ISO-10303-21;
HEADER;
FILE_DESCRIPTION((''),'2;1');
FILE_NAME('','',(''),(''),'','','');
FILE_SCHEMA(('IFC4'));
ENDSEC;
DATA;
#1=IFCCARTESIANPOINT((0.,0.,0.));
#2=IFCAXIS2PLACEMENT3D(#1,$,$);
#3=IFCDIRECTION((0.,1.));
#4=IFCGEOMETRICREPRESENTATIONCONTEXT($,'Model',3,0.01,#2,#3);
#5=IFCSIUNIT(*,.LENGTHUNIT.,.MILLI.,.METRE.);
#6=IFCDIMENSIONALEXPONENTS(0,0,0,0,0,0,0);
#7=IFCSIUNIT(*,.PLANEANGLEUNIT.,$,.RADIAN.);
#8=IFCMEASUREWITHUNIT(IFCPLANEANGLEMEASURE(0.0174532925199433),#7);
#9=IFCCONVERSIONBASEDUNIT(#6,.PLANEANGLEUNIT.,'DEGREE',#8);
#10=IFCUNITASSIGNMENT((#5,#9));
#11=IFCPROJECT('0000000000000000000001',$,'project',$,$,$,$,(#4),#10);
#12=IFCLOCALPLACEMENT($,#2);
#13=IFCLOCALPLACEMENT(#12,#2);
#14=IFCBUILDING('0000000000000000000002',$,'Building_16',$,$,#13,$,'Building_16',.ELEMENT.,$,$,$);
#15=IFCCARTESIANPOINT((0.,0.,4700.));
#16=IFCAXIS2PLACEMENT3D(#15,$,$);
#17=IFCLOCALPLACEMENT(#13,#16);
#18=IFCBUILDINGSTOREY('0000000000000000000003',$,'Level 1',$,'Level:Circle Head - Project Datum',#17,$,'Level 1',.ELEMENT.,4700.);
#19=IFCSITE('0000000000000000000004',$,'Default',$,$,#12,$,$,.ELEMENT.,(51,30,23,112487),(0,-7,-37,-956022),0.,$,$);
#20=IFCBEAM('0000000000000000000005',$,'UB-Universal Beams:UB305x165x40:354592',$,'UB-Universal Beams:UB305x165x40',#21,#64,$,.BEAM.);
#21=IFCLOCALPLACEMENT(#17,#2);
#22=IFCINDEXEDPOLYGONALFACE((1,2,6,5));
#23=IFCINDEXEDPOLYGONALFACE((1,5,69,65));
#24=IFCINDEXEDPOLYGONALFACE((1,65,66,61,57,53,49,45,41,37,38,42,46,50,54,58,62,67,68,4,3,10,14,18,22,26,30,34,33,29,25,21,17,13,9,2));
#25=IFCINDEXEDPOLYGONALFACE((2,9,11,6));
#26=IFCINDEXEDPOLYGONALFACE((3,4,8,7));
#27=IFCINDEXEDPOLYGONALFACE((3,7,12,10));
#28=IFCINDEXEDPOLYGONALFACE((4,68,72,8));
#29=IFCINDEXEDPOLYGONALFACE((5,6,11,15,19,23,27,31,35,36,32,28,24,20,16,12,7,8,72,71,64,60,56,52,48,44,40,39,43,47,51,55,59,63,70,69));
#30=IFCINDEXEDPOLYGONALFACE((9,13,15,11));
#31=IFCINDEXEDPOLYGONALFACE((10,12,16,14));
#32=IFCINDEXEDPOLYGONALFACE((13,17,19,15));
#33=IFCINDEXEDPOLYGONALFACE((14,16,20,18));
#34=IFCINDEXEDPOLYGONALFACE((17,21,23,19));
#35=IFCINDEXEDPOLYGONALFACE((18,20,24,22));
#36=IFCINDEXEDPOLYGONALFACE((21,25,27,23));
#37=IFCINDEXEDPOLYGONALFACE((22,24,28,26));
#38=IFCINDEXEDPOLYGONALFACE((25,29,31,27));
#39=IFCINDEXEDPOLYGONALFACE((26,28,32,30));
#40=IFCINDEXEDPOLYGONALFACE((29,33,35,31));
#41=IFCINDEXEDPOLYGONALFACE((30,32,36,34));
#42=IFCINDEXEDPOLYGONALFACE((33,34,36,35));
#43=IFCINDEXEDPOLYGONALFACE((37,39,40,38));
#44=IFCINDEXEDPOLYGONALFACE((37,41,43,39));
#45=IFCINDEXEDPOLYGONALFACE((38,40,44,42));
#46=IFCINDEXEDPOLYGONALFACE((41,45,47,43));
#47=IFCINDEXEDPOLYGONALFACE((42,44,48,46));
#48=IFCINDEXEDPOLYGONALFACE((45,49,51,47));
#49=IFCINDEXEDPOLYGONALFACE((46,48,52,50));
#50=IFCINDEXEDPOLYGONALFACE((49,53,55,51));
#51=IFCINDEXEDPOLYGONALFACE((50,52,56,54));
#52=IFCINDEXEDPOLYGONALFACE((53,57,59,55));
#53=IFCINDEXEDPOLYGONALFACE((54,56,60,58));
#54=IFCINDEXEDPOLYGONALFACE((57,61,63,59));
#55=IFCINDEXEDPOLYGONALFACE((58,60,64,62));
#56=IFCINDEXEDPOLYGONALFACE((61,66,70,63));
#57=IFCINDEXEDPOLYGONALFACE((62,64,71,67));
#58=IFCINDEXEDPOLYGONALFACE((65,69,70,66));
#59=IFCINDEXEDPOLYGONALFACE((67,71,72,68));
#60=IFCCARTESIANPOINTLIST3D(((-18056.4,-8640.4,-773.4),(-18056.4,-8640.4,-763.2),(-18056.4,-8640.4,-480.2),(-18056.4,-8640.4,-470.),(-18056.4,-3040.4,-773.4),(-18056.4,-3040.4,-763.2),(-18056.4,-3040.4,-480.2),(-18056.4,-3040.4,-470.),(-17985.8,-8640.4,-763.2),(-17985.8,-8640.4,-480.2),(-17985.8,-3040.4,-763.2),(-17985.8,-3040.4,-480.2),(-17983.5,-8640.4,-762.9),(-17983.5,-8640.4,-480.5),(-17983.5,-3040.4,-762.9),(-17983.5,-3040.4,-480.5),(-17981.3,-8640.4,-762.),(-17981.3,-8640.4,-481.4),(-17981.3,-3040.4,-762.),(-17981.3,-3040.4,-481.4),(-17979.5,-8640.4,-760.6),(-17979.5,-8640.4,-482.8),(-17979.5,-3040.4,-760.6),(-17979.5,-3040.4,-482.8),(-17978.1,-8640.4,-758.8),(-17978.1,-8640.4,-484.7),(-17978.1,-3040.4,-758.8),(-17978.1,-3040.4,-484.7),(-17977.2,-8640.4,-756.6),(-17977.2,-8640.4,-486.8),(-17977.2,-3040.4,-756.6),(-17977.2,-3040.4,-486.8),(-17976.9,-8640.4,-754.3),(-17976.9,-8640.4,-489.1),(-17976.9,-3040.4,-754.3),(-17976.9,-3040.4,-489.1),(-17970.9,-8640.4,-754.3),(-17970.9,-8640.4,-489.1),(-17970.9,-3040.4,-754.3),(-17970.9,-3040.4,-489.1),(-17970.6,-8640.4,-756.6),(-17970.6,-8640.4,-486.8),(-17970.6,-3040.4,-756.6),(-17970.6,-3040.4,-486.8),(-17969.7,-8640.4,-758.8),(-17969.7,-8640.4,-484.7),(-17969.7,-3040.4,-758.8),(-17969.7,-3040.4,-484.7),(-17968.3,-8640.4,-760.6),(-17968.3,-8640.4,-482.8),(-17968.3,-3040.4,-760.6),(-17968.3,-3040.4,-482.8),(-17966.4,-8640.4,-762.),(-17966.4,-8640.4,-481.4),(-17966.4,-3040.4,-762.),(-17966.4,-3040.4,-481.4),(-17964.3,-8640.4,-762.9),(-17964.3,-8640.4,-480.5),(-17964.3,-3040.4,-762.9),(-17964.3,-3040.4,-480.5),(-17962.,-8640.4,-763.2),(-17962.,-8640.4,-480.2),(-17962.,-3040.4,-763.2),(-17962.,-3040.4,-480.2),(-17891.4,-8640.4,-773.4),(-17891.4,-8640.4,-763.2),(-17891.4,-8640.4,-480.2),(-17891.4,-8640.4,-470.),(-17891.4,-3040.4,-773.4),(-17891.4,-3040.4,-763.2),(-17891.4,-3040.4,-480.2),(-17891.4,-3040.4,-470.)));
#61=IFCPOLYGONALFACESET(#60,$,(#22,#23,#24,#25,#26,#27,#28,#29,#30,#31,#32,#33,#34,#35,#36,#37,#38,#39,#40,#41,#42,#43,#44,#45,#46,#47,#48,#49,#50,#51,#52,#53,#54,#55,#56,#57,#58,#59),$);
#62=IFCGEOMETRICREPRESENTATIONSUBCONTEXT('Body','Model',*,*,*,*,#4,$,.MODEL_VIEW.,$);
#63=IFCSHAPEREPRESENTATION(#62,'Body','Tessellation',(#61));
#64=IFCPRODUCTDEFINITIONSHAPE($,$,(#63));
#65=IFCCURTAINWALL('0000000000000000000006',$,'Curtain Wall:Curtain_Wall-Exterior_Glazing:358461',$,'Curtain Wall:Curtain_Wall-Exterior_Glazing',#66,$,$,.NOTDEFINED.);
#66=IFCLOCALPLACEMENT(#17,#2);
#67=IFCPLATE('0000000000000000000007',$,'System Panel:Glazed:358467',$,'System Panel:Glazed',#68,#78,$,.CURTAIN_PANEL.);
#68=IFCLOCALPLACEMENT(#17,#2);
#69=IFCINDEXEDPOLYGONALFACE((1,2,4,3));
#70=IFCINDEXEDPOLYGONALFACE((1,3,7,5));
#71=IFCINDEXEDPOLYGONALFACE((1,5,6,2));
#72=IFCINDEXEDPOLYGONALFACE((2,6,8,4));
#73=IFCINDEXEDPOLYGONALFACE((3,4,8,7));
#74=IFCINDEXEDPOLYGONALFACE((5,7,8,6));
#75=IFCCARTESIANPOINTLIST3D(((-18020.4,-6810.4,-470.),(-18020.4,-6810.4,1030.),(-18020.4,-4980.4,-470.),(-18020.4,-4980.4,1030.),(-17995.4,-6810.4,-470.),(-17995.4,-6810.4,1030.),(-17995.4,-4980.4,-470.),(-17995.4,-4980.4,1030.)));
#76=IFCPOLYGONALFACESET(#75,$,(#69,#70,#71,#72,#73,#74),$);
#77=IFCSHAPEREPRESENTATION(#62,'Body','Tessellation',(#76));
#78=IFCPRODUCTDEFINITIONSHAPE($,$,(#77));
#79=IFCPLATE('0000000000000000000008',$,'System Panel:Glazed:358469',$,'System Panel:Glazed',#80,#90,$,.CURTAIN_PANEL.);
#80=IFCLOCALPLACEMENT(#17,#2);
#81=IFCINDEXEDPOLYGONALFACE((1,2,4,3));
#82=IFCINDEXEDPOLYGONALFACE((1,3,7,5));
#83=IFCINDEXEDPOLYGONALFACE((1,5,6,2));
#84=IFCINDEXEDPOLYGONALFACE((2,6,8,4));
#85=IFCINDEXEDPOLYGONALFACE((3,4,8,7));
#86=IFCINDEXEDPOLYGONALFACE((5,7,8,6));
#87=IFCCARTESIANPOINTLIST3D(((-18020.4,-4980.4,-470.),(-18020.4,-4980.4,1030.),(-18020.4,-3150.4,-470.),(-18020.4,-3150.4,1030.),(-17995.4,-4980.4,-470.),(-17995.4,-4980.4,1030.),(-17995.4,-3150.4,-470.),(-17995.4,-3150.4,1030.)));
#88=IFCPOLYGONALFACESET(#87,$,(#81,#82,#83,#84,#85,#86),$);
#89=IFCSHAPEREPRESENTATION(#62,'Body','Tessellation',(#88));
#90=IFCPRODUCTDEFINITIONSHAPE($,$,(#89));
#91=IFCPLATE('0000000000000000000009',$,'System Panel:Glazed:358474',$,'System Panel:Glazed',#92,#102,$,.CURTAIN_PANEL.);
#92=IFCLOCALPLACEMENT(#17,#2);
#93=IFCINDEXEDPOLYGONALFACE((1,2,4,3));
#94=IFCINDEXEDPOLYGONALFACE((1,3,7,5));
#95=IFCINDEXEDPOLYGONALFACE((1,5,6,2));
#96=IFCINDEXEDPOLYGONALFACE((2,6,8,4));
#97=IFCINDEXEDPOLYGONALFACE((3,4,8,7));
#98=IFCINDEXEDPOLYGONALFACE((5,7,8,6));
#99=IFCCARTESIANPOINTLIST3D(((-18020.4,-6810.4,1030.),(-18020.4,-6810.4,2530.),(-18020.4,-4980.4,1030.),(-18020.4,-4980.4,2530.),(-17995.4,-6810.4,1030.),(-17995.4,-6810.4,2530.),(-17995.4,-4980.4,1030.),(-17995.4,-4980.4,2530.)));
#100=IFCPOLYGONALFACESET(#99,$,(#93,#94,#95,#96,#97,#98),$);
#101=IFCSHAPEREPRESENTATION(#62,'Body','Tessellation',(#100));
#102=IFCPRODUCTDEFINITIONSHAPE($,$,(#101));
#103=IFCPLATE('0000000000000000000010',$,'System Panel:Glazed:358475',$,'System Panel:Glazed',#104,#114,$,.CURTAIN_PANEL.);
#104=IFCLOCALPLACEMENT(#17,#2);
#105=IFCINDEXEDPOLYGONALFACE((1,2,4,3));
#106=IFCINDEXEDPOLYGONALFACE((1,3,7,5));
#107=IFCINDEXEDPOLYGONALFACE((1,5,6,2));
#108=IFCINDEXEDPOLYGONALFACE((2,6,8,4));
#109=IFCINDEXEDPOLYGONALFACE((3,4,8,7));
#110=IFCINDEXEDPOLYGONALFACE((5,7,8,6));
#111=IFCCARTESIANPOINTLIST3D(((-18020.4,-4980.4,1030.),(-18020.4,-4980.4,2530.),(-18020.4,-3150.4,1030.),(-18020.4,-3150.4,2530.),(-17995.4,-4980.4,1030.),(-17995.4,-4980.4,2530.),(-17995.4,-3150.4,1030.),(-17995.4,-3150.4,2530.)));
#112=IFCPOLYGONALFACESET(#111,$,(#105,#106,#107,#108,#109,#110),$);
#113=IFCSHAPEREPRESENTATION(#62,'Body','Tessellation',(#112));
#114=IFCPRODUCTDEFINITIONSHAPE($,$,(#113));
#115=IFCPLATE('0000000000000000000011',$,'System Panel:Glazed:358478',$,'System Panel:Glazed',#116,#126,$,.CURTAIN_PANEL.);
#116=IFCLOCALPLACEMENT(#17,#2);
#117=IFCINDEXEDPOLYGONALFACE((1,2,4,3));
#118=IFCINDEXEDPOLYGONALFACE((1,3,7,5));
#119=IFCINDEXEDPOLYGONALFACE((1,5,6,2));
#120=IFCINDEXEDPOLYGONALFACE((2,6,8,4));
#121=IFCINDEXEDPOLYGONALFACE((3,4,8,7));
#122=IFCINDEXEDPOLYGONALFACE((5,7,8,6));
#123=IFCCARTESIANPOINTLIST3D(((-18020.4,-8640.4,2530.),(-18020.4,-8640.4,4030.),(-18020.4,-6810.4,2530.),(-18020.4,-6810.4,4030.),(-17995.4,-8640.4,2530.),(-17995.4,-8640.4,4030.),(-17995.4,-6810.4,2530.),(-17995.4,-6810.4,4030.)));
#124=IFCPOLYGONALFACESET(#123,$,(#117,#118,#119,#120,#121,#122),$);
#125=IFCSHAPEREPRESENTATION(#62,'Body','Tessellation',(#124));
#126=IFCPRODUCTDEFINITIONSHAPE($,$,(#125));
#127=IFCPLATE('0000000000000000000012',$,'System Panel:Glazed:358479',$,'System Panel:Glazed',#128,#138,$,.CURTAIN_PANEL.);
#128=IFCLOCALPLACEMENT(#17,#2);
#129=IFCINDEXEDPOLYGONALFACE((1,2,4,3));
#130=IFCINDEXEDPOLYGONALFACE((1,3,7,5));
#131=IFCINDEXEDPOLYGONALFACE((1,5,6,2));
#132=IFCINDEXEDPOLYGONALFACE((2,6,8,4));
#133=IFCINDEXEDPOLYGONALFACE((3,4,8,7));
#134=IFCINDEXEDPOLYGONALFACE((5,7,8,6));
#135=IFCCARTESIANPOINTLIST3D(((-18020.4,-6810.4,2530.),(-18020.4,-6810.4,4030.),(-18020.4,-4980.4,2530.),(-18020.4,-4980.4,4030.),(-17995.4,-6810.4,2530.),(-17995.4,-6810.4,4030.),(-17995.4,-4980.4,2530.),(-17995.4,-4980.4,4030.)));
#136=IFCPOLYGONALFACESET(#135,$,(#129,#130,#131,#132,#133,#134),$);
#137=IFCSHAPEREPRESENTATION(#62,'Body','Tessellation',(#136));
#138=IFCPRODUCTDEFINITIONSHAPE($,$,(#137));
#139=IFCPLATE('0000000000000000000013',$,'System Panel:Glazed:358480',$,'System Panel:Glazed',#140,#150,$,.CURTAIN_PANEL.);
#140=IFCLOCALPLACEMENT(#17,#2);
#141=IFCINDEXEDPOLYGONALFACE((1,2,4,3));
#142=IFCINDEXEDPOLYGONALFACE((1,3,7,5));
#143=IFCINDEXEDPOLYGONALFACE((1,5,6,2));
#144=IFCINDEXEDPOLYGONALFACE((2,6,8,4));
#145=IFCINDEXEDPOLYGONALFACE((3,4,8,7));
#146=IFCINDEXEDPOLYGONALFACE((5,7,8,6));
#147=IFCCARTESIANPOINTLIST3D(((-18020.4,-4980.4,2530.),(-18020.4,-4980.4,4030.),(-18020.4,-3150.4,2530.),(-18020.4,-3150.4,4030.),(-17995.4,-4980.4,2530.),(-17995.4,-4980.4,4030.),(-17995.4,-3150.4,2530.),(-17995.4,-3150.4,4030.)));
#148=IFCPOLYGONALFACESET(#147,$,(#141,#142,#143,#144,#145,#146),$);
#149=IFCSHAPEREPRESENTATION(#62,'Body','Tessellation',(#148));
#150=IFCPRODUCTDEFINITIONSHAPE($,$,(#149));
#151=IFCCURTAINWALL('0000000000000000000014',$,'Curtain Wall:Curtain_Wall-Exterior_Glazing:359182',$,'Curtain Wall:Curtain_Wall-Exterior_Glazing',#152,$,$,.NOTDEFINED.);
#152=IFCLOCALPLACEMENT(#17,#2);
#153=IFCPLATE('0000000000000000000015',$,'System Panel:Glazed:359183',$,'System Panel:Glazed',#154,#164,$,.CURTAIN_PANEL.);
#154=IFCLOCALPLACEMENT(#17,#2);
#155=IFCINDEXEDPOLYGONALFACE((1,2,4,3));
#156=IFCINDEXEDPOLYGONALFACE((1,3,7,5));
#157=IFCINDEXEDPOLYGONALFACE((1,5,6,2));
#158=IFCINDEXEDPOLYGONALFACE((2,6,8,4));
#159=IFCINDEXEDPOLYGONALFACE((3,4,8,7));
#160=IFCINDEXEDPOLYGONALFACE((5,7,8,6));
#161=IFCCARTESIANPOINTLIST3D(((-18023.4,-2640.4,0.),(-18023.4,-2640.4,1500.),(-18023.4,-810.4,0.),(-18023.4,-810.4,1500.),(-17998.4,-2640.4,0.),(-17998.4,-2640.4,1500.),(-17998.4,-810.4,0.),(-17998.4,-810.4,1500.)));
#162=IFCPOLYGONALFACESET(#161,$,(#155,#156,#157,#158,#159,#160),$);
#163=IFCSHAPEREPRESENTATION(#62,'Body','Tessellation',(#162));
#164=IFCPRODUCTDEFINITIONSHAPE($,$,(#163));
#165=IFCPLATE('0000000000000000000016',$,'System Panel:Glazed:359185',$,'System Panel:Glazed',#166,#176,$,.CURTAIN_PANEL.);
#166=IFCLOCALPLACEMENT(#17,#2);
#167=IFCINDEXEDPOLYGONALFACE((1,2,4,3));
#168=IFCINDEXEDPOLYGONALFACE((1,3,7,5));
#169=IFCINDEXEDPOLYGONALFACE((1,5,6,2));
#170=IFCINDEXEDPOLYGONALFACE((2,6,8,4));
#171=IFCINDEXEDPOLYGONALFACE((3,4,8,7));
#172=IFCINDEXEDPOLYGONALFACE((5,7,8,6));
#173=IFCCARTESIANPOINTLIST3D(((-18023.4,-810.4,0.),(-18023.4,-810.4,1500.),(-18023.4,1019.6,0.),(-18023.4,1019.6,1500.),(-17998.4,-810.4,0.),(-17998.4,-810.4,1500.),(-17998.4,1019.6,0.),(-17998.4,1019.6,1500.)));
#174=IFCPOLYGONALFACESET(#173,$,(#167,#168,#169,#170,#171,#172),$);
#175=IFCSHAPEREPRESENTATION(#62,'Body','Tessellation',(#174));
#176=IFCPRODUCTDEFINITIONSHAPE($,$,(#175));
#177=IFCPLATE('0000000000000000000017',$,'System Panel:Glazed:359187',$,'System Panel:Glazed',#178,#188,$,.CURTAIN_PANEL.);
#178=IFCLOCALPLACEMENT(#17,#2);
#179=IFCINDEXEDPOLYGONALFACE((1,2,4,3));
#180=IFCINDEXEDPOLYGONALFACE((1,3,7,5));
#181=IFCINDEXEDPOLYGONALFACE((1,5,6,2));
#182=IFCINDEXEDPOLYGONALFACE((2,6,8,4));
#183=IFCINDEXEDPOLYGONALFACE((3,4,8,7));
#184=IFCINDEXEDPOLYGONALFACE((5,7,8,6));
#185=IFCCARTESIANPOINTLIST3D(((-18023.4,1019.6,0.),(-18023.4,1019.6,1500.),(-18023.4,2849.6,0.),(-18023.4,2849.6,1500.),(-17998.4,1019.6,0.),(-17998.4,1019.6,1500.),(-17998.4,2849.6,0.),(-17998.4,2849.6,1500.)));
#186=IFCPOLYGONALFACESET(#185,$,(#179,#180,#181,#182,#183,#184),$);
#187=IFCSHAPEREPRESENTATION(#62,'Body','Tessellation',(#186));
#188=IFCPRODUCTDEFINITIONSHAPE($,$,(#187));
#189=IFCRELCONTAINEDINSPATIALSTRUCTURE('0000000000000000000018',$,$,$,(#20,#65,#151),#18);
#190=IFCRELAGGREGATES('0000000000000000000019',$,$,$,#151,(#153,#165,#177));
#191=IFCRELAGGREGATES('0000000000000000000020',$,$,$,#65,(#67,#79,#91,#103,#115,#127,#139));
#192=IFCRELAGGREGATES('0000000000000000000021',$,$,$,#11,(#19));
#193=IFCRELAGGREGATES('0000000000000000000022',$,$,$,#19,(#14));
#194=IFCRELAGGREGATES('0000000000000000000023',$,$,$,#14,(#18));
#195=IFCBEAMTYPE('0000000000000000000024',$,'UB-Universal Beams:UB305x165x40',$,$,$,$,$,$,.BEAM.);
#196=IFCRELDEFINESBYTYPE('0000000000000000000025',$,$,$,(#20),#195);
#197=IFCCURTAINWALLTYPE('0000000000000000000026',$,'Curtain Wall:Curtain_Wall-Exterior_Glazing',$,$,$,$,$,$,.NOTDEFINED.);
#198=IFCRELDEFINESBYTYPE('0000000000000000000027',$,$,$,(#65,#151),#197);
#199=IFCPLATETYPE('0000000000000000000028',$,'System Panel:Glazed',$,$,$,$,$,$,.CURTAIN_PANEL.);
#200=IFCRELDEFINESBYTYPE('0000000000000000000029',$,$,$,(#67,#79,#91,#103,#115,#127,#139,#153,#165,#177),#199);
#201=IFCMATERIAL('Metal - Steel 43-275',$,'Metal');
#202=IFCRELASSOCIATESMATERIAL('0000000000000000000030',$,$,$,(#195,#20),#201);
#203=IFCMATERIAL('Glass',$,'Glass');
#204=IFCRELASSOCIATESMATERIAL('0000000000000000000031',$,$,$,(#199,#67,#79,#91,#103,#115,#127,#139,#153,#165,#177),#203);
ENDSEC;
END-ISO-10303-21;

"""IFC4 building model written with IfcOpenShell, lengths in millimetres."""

from ifc_helpers import new_model, entity, si_unit, converted_unit, direction, frame, origin, place, context, subcontext, project, spatial, line, arc, indexed_curve, outline, extrude, source, transform, mapped, material, type_object, type_shapes, element, aggregate, save


model = new_model("IFC4")

# Units and contexts
model_context = context("Model", 3, precision=0.01, world=origin(), true_north=direction((0.0, 1.0)))
body_context = subcontext(model_context, "Body", "Model", "MODEL_VIEW")
ifc_project = project(units=[si_unit("LENGTHUNIT", "METRE", prefix="MILLI"), converted_unit("PLANEANGLEUNIT", "DEGREE", entity("IfcPlaneAngleMeasure", 0.0174532925199433), si_unit("PLANEANGLEUNIT", "RADIAN"), dimensions=[0, 0, 0, 0, 0, 0, 0])], contexts=[model_context])

# Site, building, storey
site_placement = place(None, origin())
site = spatial("IfcSite", under=ifc_project, at=site_placement, Name="Default", CompositionType="ELEMENT", RefLatitude=(51, 30, 23, 112487), RefLongitude=(0, -7, -37, -956022), RefElevation=0.0)
building_placement = place(site_placement, origin())
building = spatial("IfcBuilding", under=site, at=building_placement, Name="Building_16", LongName="Building_16", CompositionType="ELEMENT")
storey_placement = place(building_placement, frame((0.0, 0.0, 4700.0)))
storey = spatial("IfcBuildingStorey", under=building, at=storey_placement, Name="Level 1", ObjectType="Level:Circle Head - Project Datum", LongName="Level 1", CompositionType="ELEMENT", Elevation=4700.0)

# Beam
ifc_material_1 = material(Name="Metal - Steel 43-275", Category="Metal")
beam_type = type_object("IfcBeamType", Name="UB-Universal Beams:UB305x165x40", PredefinedType="BEAM", material=ifc_material_1)
shared_shape_1 = source(origin(), body_context, "Body", "SweptSolid", [
    extrude(outline(indexed_curve([(-82.5, -141.5), (-82.5, -151.7), (82.5, -151.7), (82.5, -141.5), (11.9, -141.5), (5.6, -138.9), (3.0, -132.6), (3.0, 132.6), (5.6, 138.9), (11.9, 141.5), (82.5, 141.5), (82.5, 151.7), (-82.5, 151.7), (-82.5, 141.5), (-11.9, 141.5), (-5.6, 138.9), (-3.0, 132.6), (-3.0, -132.6), (-5.6, -138.9), (-11.9, -141.5)], segments=[line(1, 2, 3, 4, 5), arc(5, 6, 7), line(7, 8), arc(8, 9, 10), line(10, 11, 12, 13, 14, 15), arc(15, 16, 17), line(17, 18), arc(18, 19, 20), line(20, 1)], self_intersect=False)), frame((-2800.0, 0.0, 0.0), z_axis=(-1.0, 0.0, 0.0), x_axis=(0.0, -1.0, 0.0)), (0.0, 0.0, -1.0), 5600.0),
])
type_shapes(beam_type, [shared_shape_1])
beam_placement = place(storey_placement, frame((-17973.9, -5840.4, -621.7), z_axis=(0.0, 0.0, 1.0), x_axis=(0.0, 1.0, 0.0)))
element("IfcBeam", 1, at=beam_placement, inside=storey, type_object=beam_type, material=ifc_material_1, Name="UB-Universal Beams:UB305x165x40:354592", ObjectType="UB-Universal Beams:UB305x165x40", PredefinedType="BEAM", context=body_context, shape_type="MappedRepresentation", body=[
    mapped(shared_shape_1, transform((0.0, 0.0, 0.0), scale=1.0)),
])

# Curtain walls, plates
curtain_wall_type = type_object("IfcCurtainWallType", Name="Curtain Wall:Curtain_Wall-Exterior_Glazing", PredefinedType="NOTDEFINED")
curtain_wall_1_placement = place(storey_placement, frame((0.0, 0.0, -4700.0)))
curtain_wall_1 = element("IfcCurtainWall", 2, at=curtain_wall_1_placement, inside=storey, type_object=curtain_wall_type, Name="Curtain Wall:Curtain_Wall-Exterior_Glazing:358461", ObjectType="Curtain Wall:Curtain_Wall-Exterior_Glazing", PredefinedType="NOTDEFINED")
ifc_material_2 = material(Name="Glass", Category="Glass")
plate_type_1 = type_object("IfcPlateType", Name="System Panel:Glazed", PredefinedType="CURTAIN_PANEL", material=ifc_material_2)
shared_shape_2 = source(origin(), body_context, "Body", "SweptSolid", [
    extrude(outline(indexed_curve([(-12.5, -915.0), (12.5, -915.0), (12.5, 915.0), (-12.5, 915.0), (-12.5, -915.0)], self_intersect=False)), frame((0.0, 37.0, 0.0), z_axis=(0.0, 0.0, 1.0), x_axis=(0.0, 1.0, 0.0)), (0.0, 0.0, 1.0), 1500.0),
])
type_shapes(plate_type_1, [shared_shape_2])
plate_1_placement = place(curtain_wall_1_placement, frame((-17970.9, -5895.4, 4230.0), z_axis=(0.0, 0.0, 1.0), x_axis=(0.0, 1.0, 0.0)))
plate_1 = element("IfcPlate", 3, at=plate_1_placement, type_object=plate_type_1, material=ifc_material_2, Name="System Panel:Glazed:358467", ObjectType="System Panel:Glazed", PredefinedType="CURTAIN_PANEL", context=body_context, shape_type="MappedRepresentation", body=[
    mapped(shared_shape_2, transform((0.0, 0.0, 0.0), scale=1.0)),
])
plate_2_placement = place(curtain_wall_1_placement, frame((-17970.9, -4065.4, 4230.0), z_axis=(0.0, 0.0, 1.0), x_axis=(0.0, 1.0, 0.0)))
plate_2 = element("IfcPlate", 4, at=plate_2_placement, type_object=plate_type_1, material=ifc_material_2, Name="System Panel:Glazed:358469", ObjectType="System Panel:Glazed", PredefinedType="CURTAIN_PANEL", context=body_context, shape_type="MappedRepresentation", body=[
    mapped(shared_shape_2, transform((0.0, 0.0, 0.0), scale=1.0)),
])
plate_3_placement = place(curtain_wall_1_placement, frame((-17970.9, -5895.4, 5730.0), z_axis=(0.0, 0.0, 1.0), x_axis=(0.0, 1.0, 0.0)))
plate_3 = element("IfcPlate", 5, at=plate_3_placement, type_object=plate_type_1, material=ifc_material_2, Name="System Panel:Glazed:358474", ObjectType="System Panel:Glazed", PredefinedType="CURTAIN_PANEL", context=body_context, shape_type="MappedRepresentation", body=[
    mapped(shared_shape_2, transform((0.0, 0.0, 0.0), scale=1.0)),
])
plate_4_placement = place(curtain_wall_1_placement, frame((-17970.9, -4065.4, 5730.0), z_axis=(0.0, 0.0, 1.0), x_axis=(0.0, 1.0, 0.0)))
plate_4 = element("IfcPlate", 6, at=plate_4_placement, type_object=plate_type_1, material=ifc_material_2, Name="System Panel:Glazed:358475", ObjectType="System Panel:Glazed", PredefinedType="CURTAIN_PANEL", context=body_context, shape_type="MappedRepresentation", body=[
    mapped(shared_shape_2, transform((0.0, 0.0, 0.0), scale=1.0)),
])
plate_5_placement = place(curtain_wall_1_placement, frame((-17970.9, -7725.4, 7230.0), z_axis=(0.0, 0.0, 1.0), x_axis=(0.0, 1.0, 0.0)))
plate_5 = element("IfcPlate", 7, at=plate_5_placement, type_object=plate_type_1, material=ifc_material_2, Name="System Panel:Glazed:358478", ObjectType="System Panel:Glazed", PredefinedType="CURTAIN_PANEL", context=body_context, shape_type="MappedRepresentation", body=[
    mapped(shared_shape_2, transform((0.0, 0.0, 0.0), scale=1.0)),
])
plate_6_placement = place(curtain_wall_1_placement, frame((-17970.9, -5895.4, 7230.0), z_axis=(0.0, 0.0, 1.0), x_axis=(0.0, 1.0, 0.0)))
plate_6 = element("IfcPlate", 8, at=plate_6_placement, type_object=plate_type_1, material=ifc_material_2, Name="System Panel:Glazed:358479", ObjectType="System Panel:Glazed", PredefinedType="CURTAIN_PANEL", context=body_context, shape_type="MappedRepresentation", body=[
    mapped(shared_shape_2, transform((0.0, 0.0, 0.0), scale=1.0)),
])
plate_7_placement = place(curtain_wall_1_placement, frame((-17970.9, -4065.4, 7230.0), z_axis=(0.0, 0.0, 1.0), x_axis=(0.0, 1.0, 0.0)))
plate_7 = element("IfcPlate", 9, at=plate_7_placement, type_object=plate_type_1, material=ifc_material_2, Name="System Panel:Glazed:358480", ObjectType="System Panel:Glazed", PredefinedType="CURTAIN_PANEL", context=body_context, shape_type="MappedRepresentation", body=[
    mapped(shared_shape_2, transform((0.0, 0.0, 0.0), scale=1.0)),
])
curtain_wall_2_placement = place(storey_placement, frame((0.0, 0.0, -4700.0)))
curtain_wall_2 = element("IfcCurtainWall", 10, at=curtain_wall_2_placement, inside=storey, type_object=curtain_wall_type, Name="Curtain Wall:Curtain_Wall-Exterior_Glazing:359182", ObjectType="Curtain Wall:Curtain_Wall-Exterior_Glazing", PredefinedType="NOTDEFINED")
plate_8_placement = place(curtain_wall_2_placement, frame((-17973.9, -1725.4, 4700.0), z_axis=(0.0, 0.0, 1.0), x_axis=(0.0, 1.0, 0.0)))
plate_8 = element("IfcPlate", 11, at=plate_8_placement, type_object=plate_type_1, material=ifc_material_2, Name="System Panel:Glazed:359183", ObjectType="System Panel:Glazed", PredefinedType="CURTAIN_PANEL", context=body_context, shape_type="MappedRepresentation", body=[
    mapped(shared_shape_2, transform((0.0, 0.0, 0.0), scale=1.0)),
])
plate_9_placement = place(curtain_wall_2_placement, frame((-17973.9, 104.6, 4700.0), z_axis=(0.0, 0.0, 1.0), x_axis=(0.0, 1.0, 0.0)))
plate_9 = element("IfcPlate", 12, at=plate_9_placement, type_object=plate_type_1, material=ifc_material_2, Name="System Panel:Glazed:359185", ObjectType="System Panel:Glazed", PredefinedType="CURTAIN_PANEL", context=body_context, shape_type="MappedRepresentation", body=[
    mapped(shared_shape_2, transform((0.0, 0.0, 0.0), scale=1.0)),
])
plate_10_placement = place(curtain_wall_2_placement, frame((-17973.9, 1934.6, 4700.0), z_axis=(0.0, 0.0, 1.0), x_axis=(0.0, 1.0, 0.0)))
plate_10 = element("IfcPlate", 13, at=plate_10_placement, type_object=plate_type_1, material=ifc_material_2, Name="System Panel:Glazed:359187", ObjectType="System Panel:Glazed", PredefinedType="CURTAIN_PANEL", context=body_context, shape_type="MappedRepresentation", body=[
    mapped(shared_shape_2, transform((0.0, 0.0, 0.0), scale=1.0)),
])

aggregate(curtain_wall_2, [plate_8, plate_9, plate_10])
aggregate(curtain_wall_1, [plate_1, plate_2, plate_3, plate_4, plate_5, plate_6, plate_7])

save(model, "model.ifc")
